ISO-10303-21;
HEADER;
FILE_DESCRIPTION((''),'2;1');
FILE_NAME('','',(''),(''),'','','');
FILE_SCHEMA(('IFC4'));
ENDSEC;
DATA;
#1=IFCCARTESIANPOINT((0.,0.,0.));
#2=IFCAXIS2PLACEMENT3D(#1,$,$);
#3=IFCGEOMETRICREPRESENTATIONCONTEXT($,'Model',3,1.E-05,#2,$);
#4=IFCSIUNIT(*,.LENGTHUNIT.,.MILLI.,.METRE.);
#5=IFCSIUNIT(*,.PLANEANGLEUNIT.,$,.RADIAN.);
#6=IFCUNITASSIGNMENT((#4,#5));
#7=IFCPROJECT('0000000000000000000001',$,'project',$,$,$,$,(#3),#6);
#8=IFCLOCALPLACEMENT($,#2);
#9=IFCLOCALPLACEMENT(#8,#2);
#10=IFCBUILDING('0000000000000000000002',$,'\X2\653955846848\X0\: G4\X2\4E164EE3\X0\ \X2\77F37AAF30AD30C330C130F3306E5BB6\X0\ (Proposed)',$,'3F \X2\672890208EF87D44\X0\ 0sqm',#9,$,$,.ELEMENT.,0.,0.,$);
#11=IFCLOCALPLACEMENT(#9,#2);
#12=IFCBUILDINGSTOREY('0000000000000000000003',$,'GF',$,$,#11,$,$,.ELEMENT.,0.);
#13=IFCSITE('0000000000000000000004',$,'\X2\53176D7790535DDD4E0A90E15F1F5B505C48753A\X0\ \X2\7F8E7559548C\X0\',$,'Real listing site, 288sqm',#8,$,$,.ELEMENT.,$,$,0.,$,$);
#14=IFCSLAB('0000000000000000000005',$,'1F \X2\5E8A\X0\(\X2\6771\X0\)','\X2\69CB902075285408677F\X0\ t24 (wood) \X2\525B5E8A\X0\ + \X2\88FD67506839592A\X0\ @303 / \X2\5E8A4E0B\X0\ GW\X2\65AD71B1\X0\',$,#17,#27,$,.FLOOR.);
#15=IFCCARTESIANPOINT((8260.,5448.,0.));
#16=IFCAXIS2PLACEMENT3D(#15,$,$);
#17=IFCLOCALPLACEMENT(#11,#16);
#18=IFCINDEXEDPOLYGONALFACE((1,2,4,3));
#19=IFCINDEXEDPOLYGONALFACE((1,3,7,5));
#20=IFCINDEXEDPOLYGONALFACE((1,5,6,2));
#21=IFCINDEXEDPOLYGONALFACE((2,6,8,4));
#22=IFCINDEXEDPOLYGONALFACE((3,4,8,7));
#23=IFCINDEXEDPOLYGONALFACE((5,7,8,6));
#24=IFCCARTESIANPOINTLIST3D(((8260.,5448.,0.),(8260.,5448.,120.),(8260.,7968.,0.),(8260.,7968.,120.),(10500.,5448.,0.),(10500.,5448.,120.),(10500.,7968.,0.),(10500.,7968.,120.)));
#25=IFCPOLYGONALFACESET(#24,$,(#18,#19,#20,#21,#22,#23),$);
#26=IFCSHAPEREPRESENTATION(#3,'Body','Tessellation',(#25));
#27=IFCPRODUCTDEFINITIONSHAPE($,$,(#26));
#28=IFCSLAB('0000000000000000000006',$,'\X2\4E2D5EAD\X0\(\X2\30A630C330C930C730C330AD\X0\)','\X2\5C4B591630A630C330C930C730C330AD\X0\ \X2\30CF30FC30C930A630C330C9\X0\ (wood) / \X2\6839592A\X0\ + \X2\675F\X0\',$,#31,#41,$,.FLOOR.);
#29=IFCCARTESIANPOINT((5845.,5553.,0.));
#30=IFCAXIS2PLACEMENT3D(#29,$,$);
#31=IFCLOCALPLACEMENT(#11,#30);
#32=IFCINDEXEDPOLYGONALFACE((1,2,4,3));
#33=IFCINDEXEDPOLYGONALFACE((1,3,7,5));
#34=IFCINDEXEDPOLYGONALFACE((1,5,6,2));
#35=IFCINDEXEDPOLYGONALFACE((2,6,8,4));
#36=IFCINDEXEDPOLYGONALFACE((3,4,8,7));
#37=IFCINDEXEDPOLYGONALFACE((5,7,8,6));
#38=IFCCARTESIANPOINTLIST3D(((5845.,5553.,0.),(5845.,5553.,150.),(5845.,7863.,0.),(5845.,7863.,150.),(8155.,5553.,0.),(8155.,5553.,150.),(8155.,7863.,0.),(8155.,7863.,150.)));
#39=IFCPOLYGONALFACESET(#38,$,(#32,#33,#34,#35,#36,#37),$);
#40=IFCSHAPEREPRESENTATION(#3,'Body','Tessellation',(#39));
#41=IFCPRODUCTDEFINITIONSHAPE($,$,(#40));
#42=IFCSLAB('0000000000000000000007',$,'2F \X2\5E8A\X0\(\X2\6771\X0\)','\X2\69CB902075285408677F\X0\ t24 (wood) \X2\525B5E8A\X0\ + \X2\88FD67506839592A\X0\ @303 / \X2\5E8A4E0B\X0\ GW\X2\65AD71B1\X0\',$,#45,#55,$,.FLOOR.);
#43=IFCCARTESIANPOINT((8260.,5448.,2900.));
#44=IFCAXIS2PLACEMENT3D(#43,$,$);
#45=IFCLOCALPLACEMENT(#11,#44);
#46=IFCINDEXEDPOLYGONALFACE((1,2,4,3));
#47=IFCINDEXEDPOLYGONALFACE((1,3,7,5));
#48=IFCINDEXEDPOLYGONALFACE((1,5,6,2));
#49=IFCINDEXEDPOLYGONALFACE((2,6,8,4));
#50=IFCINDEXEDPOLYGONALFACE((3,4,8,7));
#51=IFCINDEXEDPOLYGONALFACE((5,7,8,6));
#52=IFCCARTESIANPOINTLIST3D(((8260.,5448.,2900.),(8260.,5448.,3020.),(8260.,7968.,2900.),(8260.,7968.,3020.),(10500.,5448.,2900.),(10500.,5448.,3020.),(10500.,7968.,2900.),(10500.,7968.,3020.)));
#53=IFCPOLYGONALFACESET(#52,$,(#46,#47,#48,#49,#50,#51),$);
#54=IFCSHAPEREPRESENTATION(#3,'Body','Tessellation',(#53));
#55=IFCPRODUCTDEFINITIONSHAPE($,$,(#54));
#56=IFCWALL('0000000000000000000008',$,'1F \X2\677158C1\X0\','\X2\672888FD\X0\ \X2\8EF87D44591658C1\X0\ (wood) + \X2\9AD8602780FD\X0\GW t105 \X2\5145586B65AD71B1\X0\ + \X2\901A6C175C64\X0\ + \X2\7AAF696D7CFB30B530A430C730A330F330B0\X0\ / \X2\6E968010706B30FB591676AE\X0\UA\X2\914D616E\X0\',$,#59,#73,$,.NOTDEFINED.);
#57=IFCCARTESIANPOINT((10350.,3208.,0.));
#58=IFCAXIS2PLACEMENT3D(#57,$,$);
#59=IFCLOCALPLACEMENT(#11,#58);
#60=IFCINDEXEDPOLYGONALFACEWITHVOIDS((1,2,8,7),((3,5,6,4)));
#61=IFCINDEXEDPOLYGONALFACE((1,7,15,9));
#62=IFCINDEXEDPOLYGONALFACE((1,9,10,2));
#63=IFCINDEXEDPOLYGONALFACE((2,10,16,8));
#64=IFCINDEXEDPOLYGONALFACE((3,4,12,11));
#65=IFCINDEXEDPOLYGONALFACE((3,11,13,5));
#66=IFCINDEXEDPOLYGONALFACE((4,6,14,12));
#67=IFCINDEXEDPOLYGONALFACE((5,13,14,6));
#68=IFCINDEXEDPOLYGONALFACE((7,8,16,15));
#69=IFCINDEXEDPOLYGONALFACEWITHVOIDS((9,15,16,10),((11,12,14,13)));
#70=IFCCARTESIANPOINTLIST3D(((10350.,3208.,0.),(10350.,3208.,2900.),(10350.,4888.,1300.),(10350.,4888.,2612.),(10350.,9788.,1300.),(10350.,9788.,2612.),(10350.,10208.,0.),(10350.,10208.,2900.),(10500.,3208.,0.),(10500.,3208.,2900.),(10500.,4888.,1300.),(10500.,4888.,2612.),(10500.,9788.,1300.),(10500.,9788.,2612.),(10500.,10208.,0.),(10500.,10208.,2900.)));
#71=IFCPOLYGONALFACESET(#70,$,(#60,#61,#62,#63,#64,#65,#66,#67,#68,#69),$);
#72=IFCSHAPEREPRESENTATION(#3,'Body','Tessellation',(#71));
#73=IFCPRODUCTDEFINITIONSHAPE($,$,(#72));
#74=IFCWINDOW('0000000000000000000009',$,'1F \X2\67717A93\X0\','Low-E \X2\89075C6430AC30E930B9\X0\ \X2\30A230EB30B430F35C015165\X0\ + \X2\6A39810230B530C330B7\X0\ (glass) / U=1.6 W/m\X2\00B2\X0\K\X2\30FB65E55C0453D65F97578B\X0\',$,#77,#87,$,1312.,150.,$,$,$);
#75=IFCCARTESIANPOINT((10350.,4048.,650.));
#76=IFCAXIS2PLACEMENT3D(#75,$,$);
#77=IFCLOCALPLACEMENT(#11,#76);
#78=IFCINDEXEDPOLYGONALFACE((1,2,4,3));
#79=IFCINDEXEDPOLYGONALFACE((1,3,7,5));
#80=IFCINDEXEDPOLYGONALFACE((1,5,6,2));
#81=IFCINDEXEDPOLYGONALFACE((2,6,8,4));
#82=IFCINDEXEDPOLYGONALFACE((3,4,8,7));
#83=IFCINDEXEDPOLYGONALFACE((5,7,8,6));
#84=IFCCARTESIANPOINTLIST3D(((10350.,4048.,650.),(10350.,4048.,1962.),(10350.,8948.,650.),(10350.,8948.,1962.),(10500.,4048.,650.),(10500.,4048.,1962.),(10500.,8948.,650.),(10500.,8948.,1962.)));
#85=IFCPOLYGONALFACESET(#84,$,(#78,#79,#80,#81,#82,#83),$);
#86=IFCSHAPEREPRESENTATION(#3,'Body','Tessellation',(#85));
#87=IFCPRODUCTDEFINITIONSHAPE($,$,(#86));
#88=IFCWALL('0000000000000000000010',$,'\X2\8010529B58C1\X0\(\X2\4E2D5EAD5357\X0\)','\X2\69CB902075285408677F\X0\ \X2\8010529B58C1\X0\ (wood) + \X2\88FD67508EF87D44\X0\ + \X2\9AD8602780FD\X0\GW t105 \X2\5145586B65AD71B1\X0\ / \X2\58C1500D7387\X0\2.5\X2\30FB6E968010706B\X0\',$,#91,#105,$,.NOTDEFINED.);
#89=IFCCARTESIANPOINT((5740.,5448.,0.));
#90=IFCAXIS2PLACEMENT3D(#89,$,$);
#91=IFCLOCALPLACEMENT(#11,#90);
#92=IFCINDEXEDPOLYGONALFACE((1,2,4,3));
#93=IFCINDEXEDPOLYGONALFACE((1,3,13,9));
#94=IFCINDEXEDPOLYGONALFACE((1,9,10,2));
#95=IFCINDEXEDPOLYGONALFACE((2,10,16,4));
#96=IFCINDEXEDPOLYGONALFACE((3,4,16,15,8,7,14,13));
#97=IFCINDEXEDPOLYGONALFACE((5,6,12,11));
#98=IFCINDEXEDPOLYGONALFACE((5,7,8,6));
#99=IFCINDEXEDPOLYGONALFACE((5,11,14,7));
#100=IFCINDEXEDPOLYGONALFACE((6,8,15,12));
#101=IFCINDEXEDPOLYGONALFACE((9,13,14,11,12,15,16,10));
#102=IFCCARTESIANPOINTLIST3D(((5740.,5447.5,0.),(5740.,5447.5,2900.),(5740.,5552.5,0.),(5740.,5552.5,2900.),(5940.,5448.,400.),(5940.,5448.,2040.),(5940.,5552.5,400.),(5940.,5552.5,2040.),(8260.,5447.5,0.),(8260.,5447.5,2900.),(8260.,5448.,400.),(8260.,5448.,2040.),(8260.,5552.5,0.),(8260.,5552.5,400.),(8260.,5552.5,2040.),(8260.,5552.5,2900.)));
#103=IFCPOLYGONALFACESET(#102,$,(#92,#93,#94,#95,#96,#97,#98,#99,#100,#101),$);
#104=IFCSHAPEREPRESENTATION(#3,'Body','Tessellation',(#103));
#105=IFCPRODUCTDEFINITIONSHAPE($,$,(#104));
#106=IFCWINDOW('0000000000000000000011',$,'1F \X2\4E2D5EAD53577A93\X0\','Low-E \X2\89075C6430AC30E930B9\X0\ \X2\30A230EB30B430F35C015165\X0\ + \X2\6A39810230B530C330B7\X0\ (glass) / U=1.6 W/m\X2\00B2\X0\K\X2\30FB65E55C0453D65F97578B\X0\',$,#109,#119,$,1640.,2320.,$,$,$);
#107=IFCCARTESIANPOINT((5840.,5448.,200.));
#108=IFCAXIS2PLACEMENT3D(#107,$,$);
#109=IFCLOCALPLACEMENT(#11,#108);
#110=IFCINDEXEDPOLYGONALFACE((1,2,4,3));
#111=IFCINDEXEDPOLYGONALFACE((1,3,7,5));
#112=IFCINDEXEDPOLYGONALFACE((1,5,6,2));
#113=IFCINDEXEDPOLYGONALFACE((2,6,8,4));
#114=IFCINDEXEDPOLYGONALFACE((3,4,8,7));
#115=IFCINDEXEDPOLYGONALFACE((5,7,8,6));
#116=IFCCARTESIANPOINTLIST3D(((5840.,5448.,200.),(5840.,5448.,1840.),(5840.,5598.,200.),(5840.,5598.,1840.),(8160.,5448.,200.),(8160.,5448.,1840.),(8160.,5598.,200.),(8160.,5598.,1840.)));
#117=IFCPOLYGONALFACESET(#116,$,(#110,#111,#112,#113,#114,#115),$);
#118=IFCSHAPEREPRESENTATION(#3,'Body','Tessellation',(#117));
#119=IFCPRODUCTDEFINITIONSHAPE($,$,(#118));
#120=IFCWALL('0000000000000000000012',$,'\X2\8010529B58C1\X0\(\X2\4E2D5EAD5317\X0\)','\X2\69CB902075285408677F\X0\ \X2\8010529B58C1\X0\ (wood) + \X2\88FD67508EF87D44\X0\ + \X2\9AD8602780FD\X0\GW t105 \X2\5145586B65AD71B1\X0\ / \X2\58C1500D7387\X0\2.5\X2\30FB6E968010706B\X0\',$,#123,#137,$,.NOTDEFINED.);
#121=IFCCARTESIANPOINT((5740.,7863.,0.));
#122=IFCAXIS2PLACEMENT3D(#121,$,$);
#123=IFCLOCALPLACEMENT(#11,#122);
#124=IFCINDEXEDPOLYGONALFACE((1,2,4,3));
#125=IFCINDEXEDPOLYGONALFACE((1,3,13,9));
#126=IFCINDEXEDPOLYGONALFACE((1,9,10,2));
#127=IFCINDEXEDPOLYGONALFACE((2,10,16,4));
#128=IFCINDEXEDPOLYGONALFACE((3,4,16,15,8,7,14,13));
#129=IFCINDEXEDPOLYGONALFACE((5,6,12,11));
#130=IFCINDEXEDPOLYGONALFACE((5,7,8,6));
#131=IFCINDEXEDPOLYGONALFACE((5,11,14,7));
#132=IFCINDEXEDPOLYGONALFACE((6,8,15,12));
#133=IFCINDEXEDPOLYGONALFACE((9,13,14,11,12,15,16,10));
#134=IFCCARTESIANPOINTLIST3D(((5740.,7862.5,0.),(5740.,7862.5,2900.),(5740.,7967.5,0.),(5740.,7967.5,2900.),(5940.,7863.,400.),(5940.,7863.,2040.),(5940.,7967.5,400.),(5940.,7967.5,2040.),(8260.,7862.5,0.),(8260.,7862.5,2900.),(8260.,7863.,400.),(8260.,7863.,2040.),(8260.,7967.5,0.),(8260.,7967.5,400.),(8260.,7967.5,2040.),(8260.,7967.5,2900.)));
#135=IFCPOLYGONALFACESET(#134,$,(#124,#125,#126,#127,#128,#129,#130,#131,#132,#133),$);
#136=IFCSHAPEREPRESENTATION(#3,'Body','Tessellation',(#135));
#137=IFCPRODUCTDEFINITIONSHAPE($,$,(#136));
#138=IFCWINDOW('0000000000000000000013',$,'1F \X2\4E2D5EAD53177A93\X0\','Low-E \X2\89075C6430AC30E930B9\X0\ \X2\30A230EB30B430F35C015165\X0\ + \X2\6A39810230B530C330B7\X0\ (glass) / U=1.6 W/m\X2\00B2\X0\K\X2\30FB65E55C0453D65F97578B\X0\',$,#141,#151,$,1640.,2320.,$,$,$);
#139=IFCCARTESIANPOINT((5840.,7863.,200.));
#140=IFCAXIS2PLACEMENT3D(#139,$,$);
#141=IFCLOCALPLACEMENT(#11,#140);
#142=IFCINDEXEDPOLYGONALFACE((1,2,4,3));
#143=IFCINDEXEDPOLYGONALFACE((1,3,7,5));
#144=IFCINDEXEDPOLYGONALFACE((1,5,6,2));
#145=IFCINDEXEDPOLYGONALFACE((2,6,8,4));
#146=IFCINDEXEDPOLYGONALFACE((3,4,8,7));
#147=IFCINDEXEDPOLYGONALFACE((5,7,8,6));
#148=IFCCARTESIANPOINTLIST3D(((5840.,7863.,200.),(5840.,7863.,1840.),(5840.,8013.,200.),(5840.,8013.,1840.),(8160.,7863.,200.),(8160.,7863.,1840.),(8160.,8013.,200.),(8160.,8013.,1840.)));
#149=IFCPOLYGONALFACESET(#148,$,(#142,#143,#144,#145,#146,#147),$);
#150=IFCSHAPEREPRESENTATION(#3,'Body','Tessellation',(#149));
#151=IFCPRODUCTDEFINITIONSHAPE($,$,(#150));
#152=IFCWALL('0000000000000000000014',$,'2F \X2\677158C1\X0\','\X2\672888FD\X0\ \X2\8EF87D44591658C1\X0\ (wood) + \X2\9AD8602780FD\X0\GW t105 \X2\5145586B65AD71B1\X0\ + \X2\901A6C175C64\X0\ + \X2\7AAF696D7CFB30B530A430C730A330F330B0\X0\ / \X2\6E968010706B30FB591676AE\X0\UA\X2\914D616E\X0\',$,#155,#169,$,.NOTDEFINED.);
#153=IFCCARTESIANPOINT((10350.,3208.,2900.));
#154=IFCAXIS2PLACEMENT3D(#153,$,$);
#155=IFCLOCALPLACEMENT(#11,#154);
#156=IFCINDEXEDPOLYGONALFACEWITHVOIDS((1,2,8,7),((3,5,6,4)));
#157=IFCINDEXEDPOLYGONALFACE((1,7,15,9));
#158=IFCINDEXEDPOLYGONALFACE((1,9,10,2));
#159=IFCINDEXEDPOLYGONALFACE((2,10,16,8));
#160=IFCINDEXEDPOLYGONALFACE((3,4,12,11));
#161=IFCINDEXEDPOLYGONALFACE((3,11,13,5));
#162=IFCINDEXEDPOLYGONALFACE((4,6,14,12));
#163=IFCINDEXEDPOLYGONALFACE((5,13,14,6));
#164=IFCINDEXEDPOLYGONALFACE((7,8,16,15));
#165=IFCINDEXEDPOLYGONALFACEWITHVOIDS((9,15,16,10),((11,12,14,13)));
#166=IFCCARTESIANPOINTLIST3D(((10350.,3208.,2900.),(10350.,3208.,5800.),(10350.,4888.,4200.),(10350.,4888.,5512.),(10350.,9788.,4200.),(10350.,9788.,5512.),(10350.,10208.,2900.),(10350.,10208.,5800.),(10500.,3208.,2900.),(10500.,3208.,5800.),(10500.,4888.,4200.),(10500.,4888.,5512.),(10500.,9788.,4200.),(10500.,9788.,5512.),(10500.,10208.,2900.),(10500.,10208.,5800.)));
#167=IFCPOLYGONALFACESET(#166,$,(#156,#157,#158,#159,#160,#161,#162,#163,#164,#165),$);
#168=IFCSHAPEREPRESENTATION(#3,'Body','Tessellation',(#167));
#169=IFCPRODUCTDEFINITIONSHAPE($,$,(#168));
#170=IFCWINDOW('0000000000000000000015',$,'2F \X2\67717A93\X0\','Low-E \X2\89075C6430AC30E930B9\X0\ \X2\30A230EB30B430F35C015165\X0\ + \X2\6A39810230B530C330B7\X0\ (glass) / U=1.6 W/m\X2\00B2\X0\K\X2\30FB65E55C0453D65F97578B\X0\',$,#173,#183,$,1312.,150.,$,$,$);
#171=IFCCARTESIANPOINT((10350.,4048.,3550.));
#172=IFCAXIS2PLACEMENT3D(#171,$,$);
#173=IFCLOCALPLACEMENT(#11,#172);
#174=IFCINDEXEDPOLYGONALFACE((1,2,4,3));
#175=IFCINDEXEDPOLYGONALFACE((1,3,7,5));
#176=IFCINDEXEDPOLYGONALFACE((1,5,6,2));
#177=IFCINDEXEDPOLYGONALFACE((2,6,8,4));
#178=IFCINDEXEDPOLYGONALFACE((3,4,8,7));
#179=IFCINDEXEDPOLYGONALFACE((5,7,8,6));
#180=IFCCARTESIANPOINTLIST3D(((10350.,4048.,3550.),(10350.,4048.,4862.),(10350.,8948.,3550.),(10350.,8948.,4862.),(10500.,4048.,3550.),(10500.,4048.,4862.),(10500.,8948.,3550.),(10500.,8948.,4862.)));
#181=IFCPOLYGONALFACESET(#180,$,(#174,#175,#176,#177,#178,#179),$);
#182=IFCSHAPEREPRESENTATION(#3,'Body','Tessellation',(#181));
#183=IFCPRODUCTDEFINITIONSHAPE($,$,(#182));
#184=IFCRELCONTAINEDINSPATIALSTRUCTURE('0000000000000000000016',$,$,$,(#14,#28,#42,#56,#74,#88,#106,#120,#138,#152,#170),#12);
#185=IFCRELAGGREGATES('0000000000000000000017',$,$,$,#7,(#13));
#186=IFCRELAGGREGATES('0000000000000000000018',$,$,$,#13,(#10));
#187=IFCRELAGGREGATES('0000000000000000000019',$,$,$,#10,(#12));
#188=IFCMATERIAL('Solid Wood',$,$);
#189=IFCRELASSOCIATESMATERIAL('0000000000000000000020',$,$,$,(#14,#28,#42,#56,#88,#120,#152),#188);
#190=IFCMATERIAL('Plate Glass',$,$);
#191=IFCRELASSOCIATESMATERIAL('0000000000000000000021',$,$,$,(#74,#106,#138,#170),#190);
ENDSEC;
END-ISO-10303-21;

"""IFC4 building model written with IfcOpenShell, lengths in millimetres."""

from ifc_helpers import new_model, si_unit, frame, frame_2d, origin, place, context, project, spatial, rectangle, extrude, material, element, fill, save


model = new_model("IFC4")

# Units and contexts
model_context = context("Model", 3, precision=1e-05, world=origin())
ifc_project = project(units=[si_unit("LENGTHUNIT", "METRE", prefix="MILLI"), si_unit("PLANEANGLEUNIT", "RADIAN")], contexts=[model_context])

# Site, building, storey
site_placement = place(None, origin())
site = spatial("IfcSite", under=ifc_project, at=site_placement, Name="北海道川上郡弟子屈町 美留和", ObjectType="Real listing site, 288sqm", CompositionType="ELEMENT", RefElevation=0.0)
building_placement = place(site_placement, origin())
building = spatial("IfcBuilding", under=site, at=building_placement, Name="改善案: G4世代 石窯キッチンの家 (Proposed)", ObjectType="3F 木造軸組 0sqm", CompositionType="ELEMENT", ElevationOfRefHeight=0.0, ElevationOfTerrain=0.0)
storey_placement = place(building_placement, origin())
storey = spatial("IfcBuildingStorey", under=building, at=storey_placement, Name="GF", CompositionType="ELEMENT", Elevation=0.0)

# Slabs
ifc_material_1 = material(Name="Solid Wood")
slab_1_placement = place(storey_placement, frame((8260.0, 5448.0, 0.0)))
element("IfcSlab", 1, at=slab_1_placement, inside=storey, material=ifc_material_1, Name="1F 床(東)", Description="構造用合板 t24 (wood) 剛床 + 製材根太 @303 / 床下 GW断熱", PredefinedType="FLOOR", context=model_context, shape_type="SweptSolid", body=[
    extrude(rectangle(XDim=2240.0, YDim=2520.0, at=frame_2d((1120.0, 1260.0))), frame((8260.0, 5448.0, 0.0)), (0.0, 0.0, 1.0), 120.0),
])
slab_2_placement = place(storey_placement, frame((5845.0, 5553.0, 0.0)))
element("IfcSlab", 2, at=slab_2_placement, inside=storey, material=ifc_material_1, Name="中庭(ウッドデッキ)", Description="屋外ウッドデッキ ハードウッド (wood) / 根太 + 束", PredefinedType="FLOOR", context=model_context, shape_type="SweptSolid", body=[
    extrude(rectangle(XDim=2310.0, YDim=2310.0, at=frame_2d((1155.0, 1155.0))), frame((5845.0, 5553.0, 0.0)), (0.0, 0.0, 1.0), 150.0),
])
slab_3_placement = place(storey_placement, frame((8260.0, 5448.0, 2900.0)))
element("IfcSlab", 3, at=slab_3_placement, inside=storey, material=ifc_material_1, Name="2F 床(東)", Description="構造用合板 t24 (wood) 剛床 + 製材根太 @303 / 床下 GW断熱", PredefinedType="FLOOR", context=model_context, shape_type="SweptSolid", body=[
    extrude(rectangle(XDim=2240.0, YDim=2520.0, at=frame_2d((1120.0, 1260.0))), frame((8260.0, 5448.0, 2900.0)), (0.0, 0.0, 1.0), 120.0),
])

# Walls, openings, windows
wall_1_placement = place(storey_placement, frame((10350.0, 3208.0, 0.0)))
wall_1 = element("IfcWall", 4, at=wall_1_placement, inside=storey, material=ifc_material_1, Name="1F 東壁", Description="木製 軸組外壁 (wood) + 高性能GW t105 充填断熱 + 通気層 + 窯業系サイディング / 準耐火・外皮UA配慮", PredefinedType="NOTDEFINED", context=model_context, shape_type="SweptSolid", body=[
    extrude(rectangle(XDim=150.0, YDim=7000.0, at=frame_2d((75.0, 3500.0))), frame((10350.0, 3208.0, 0.0)), (0.0, 0.0, 1.0), 2900.0),
])
opening_1_placement = place(storey_placement, frame((10350.0, 4048.0, 650.0)))
opening_1 = element("IfcOpeningElement", 5, at=opening_1_placement, cuts=wall_1, PredefinedType="NOTDEFINED", context=model_context, shape_type="SweptSolid", body=[
    extrude(rectangle(XDim=150.0, YDim=4900.0, at=frame_2d((75.0, 2450.0))), frame((10350.0, 4048.0, 650.0)), (0.0, 0.0, 1.0), 1312.0),
])
ifc_material_2 = material(Name="Plate Glass")
window_1_placement = place(storey_placement, frame((10350.0, 4048.0, 650.0)))
window_1 = element("IfcWindow", 6, at=window_1_placement, inside=storey, material=ifc_material_2, Name="1F 東窓", Description="Low-E 複層ガラス アルゴン封入 + 樹脂サッシ (glass) / U=1.6 W/m²K・日射取得型", OverallHeight=1312.0, OverallWidth=150.0, context=model_context, shape_type="SweptSolid", body=[
    extrude(rectangle(XDim=150.0, YDim=4900.0, at=frame_2d((75.0, 2450.0))), frame((10350.0, 4048.0, 650.0)), (0.0, 0.0, 1.0), 1312.0),
])
fill(opening_1, window_1)
wall_2_placement = place(storey_placement, frame((5740.0, 5448.0, 0.0)))
wall_2 = element("IfcWall", 7, at=wall_2_placement, inside=storey, material=ifc_material_1, Name="耐力壁(中庭南)", Description="構造用合板 耐力壁 (wood) + 製材軸組 + 高性能GW t105 充填断熱 / 壁倍率2.5・準耐火", PredefinedType="NOTDEFINED", context=model_context, shape_type="SweptSolid", body=[
    extrude(rectangle(XDim=2520.0, YDim=105.0, at=frame_2d((1260.0, 52.0))), frame((5740.0, 5448.0, 0.0)), (0.0, 0.0, 1.0), 2900.0),
])
opening_2_placement = place(storey_placement, frame((5840.0, 5448.0, 200.0)))
opening_2 = element("IfcOpeningElement", 8, at=opening_2_placement, cuts=wall_2, PredefinedType="NOTDEFINED", context=model_context, shape_type="SweptSolid", body=[
    extrude(rectangle(XDim=2320.0, YDim=150.0, at=frame_2d((1160.0, 75.0))), frame((5840.0, 5448.0, 200.0)), (0.0, 0.0, 1.0), 1640.0),
])
window_2_placement = place(storey_placement, frame((5840.0, 5448.0, 200.0)))
window_2 = element("IfcWindow", 9, at=window_2_placement, inside=storey, material=ifc_material_2, Name="1F 中庭南窓", Description="Low-E 複層ガラス アルゴン封入 + 樹脂サッシ (glass) / U=1.6 W/m²K・日射取得型", OverallHeight=1640.0, OverallWidth=2320.0, context=model_context, shape_type="SweptSolid", body=[
    extrude(rectangle(XDim=2320.0, YDim=150.0, at=frame_2d((1160.0, 75.0))), frame((5840.0, 5448.0, 200.0)), (0.0, 0.0, 1.0), 1640.0),
])
fill(opening_2, window_2)
wall_3_placement = place(storey_placement, frame((5740.0, 7863.0, 0.0)))
wall_3 = element("IfcWall", 10, at=wall_3_placement, inside=storey, material=ifc_material_1, Name="耐力壁(中庭北)", Description="構造用合板 耐力壁 (wood) + 製材軸組 + 高性能GW t105 充填断熱 / 壁倍率2.5・準耐火", PredefinedType="NOTDEFINED", context=model_context, shape_type="SweptSolid", body=[
    extrude(rectangle(XDim=2520.0, YDim=105.0, at=frame_2d((1260.0, 52.0))), frame((5740.0, 7863.0, 0.0)), (0.0, 0.0, 1.0), 2900.0),
])
opening_3_placement = place(storey_placement, frame((5840.0, 7863.0, 200.0)))
opening_3 = element("IfcOpeningElement", 11, at=opening_3_placement, cuts=wall_3, PredefinedType="NOTDEFINED", context=model_context, shape_type="SweptSolid", body=[
    extrude(rectangle(XDim=2320.0, YDim=150.0, at=frame_2d((1160.0, 75.0))), frame((5840.0, 7863.0, 200.0)), (0.0, 0.0, 1.0), 1640.0),
])
window_3_placement = place(storey_placement, frame((5840.0, 7863.0, 200.0)))
window_3 = element("IfcWindow", 12, at=window_3_placement, inside=storey, material=ifc_material_2, Name="1F 中庭北窓", Description="Low-E 複層ガラス アルゴン封入 + 樹脂サッシ (glass) / U=1.6 W/m²K・日射取得型", OverallHeight=1640.0, OverallWidth=2320.0, context=model_context, shape_type="SweptSolid", body=[
    extrude(rectangle(XDim=2320.0, YDim=150.0, at=frame_2d((1160.0, 75.0))), frame((5840.0, 7863.0, 200.0)), (0.0, 0.0, 1.0), 1640.0),
])
fill(opening_3, window_3)

# Wall, opening, window
wall_4_placement = place(storey_placement, frame((10350.0, 3208.0, 2900.0)))
wall_4 = element("IfcWall", 13, at=wall_4_placement, inside=storey, material=ifc_material_1, Name="2F 東壁", Description="木製 軸組外壁 (wood) + 高性能GW t105 充填断熱 + 通気層 + 窯業系サイディング / 準耐火・外皮UA配慮", PredefinedType="NOTDEFINED", context=model_context, shape_type="SweptSolid", body=[
    extrude(rectangle(XDim=150.0, YDim=7000.0, at=frame_2d((75.0, 3500.0))), frame((10350.0, 3208.0, 2900.0)), (0.0, 0.0, 1.0), 2900.0),
])
opening_4_placement = place(storey_placement, frame((10350.0, 4048.0, 3550.0)))
opening_4 = element("IfcOpeningElement", 14, at=opening_4_placement, cuts=wall_4, PredefinedType="NOTDEFINED", context=model_context, shape_type="SweptSolid", body=[
    extrude(rectangle(XDim=150.0, YDim=4900.0, at=frame_2d((75.0, 2450.0))), frame((10350.0, 4048.0, 3550.0)), (0.0, 0.0, 1.0), 1312.0),
])
window_4_placement = place(storey_placement, frame((10350.0, 4048.0, 3550.0)))
window_4 = element("IfcWindow", 15, at=window_4_placement, inside=storey, material=ifc_material_2, Name="2F 東窓", Description="Low-E 複層ガラス アルゴン封入 + 樹脂サッシ (glass) / U=1.6 W/m²K・日射取得型", OverallHeight=1312.0, OverallWidth=150.0, context=model_context, shape_type="SweptSolid", body=[
    extrude(rectangle(XDim=150.0, YDim=4900.0, at=frame_2d((75.0, 2450.0))), frame((10350.0, 4048.0, 3550.0)), (0.0, 0.0, 1.0), 1312.0),
])
fill(opening_4, window_4)

save(model, "model.ifc")
